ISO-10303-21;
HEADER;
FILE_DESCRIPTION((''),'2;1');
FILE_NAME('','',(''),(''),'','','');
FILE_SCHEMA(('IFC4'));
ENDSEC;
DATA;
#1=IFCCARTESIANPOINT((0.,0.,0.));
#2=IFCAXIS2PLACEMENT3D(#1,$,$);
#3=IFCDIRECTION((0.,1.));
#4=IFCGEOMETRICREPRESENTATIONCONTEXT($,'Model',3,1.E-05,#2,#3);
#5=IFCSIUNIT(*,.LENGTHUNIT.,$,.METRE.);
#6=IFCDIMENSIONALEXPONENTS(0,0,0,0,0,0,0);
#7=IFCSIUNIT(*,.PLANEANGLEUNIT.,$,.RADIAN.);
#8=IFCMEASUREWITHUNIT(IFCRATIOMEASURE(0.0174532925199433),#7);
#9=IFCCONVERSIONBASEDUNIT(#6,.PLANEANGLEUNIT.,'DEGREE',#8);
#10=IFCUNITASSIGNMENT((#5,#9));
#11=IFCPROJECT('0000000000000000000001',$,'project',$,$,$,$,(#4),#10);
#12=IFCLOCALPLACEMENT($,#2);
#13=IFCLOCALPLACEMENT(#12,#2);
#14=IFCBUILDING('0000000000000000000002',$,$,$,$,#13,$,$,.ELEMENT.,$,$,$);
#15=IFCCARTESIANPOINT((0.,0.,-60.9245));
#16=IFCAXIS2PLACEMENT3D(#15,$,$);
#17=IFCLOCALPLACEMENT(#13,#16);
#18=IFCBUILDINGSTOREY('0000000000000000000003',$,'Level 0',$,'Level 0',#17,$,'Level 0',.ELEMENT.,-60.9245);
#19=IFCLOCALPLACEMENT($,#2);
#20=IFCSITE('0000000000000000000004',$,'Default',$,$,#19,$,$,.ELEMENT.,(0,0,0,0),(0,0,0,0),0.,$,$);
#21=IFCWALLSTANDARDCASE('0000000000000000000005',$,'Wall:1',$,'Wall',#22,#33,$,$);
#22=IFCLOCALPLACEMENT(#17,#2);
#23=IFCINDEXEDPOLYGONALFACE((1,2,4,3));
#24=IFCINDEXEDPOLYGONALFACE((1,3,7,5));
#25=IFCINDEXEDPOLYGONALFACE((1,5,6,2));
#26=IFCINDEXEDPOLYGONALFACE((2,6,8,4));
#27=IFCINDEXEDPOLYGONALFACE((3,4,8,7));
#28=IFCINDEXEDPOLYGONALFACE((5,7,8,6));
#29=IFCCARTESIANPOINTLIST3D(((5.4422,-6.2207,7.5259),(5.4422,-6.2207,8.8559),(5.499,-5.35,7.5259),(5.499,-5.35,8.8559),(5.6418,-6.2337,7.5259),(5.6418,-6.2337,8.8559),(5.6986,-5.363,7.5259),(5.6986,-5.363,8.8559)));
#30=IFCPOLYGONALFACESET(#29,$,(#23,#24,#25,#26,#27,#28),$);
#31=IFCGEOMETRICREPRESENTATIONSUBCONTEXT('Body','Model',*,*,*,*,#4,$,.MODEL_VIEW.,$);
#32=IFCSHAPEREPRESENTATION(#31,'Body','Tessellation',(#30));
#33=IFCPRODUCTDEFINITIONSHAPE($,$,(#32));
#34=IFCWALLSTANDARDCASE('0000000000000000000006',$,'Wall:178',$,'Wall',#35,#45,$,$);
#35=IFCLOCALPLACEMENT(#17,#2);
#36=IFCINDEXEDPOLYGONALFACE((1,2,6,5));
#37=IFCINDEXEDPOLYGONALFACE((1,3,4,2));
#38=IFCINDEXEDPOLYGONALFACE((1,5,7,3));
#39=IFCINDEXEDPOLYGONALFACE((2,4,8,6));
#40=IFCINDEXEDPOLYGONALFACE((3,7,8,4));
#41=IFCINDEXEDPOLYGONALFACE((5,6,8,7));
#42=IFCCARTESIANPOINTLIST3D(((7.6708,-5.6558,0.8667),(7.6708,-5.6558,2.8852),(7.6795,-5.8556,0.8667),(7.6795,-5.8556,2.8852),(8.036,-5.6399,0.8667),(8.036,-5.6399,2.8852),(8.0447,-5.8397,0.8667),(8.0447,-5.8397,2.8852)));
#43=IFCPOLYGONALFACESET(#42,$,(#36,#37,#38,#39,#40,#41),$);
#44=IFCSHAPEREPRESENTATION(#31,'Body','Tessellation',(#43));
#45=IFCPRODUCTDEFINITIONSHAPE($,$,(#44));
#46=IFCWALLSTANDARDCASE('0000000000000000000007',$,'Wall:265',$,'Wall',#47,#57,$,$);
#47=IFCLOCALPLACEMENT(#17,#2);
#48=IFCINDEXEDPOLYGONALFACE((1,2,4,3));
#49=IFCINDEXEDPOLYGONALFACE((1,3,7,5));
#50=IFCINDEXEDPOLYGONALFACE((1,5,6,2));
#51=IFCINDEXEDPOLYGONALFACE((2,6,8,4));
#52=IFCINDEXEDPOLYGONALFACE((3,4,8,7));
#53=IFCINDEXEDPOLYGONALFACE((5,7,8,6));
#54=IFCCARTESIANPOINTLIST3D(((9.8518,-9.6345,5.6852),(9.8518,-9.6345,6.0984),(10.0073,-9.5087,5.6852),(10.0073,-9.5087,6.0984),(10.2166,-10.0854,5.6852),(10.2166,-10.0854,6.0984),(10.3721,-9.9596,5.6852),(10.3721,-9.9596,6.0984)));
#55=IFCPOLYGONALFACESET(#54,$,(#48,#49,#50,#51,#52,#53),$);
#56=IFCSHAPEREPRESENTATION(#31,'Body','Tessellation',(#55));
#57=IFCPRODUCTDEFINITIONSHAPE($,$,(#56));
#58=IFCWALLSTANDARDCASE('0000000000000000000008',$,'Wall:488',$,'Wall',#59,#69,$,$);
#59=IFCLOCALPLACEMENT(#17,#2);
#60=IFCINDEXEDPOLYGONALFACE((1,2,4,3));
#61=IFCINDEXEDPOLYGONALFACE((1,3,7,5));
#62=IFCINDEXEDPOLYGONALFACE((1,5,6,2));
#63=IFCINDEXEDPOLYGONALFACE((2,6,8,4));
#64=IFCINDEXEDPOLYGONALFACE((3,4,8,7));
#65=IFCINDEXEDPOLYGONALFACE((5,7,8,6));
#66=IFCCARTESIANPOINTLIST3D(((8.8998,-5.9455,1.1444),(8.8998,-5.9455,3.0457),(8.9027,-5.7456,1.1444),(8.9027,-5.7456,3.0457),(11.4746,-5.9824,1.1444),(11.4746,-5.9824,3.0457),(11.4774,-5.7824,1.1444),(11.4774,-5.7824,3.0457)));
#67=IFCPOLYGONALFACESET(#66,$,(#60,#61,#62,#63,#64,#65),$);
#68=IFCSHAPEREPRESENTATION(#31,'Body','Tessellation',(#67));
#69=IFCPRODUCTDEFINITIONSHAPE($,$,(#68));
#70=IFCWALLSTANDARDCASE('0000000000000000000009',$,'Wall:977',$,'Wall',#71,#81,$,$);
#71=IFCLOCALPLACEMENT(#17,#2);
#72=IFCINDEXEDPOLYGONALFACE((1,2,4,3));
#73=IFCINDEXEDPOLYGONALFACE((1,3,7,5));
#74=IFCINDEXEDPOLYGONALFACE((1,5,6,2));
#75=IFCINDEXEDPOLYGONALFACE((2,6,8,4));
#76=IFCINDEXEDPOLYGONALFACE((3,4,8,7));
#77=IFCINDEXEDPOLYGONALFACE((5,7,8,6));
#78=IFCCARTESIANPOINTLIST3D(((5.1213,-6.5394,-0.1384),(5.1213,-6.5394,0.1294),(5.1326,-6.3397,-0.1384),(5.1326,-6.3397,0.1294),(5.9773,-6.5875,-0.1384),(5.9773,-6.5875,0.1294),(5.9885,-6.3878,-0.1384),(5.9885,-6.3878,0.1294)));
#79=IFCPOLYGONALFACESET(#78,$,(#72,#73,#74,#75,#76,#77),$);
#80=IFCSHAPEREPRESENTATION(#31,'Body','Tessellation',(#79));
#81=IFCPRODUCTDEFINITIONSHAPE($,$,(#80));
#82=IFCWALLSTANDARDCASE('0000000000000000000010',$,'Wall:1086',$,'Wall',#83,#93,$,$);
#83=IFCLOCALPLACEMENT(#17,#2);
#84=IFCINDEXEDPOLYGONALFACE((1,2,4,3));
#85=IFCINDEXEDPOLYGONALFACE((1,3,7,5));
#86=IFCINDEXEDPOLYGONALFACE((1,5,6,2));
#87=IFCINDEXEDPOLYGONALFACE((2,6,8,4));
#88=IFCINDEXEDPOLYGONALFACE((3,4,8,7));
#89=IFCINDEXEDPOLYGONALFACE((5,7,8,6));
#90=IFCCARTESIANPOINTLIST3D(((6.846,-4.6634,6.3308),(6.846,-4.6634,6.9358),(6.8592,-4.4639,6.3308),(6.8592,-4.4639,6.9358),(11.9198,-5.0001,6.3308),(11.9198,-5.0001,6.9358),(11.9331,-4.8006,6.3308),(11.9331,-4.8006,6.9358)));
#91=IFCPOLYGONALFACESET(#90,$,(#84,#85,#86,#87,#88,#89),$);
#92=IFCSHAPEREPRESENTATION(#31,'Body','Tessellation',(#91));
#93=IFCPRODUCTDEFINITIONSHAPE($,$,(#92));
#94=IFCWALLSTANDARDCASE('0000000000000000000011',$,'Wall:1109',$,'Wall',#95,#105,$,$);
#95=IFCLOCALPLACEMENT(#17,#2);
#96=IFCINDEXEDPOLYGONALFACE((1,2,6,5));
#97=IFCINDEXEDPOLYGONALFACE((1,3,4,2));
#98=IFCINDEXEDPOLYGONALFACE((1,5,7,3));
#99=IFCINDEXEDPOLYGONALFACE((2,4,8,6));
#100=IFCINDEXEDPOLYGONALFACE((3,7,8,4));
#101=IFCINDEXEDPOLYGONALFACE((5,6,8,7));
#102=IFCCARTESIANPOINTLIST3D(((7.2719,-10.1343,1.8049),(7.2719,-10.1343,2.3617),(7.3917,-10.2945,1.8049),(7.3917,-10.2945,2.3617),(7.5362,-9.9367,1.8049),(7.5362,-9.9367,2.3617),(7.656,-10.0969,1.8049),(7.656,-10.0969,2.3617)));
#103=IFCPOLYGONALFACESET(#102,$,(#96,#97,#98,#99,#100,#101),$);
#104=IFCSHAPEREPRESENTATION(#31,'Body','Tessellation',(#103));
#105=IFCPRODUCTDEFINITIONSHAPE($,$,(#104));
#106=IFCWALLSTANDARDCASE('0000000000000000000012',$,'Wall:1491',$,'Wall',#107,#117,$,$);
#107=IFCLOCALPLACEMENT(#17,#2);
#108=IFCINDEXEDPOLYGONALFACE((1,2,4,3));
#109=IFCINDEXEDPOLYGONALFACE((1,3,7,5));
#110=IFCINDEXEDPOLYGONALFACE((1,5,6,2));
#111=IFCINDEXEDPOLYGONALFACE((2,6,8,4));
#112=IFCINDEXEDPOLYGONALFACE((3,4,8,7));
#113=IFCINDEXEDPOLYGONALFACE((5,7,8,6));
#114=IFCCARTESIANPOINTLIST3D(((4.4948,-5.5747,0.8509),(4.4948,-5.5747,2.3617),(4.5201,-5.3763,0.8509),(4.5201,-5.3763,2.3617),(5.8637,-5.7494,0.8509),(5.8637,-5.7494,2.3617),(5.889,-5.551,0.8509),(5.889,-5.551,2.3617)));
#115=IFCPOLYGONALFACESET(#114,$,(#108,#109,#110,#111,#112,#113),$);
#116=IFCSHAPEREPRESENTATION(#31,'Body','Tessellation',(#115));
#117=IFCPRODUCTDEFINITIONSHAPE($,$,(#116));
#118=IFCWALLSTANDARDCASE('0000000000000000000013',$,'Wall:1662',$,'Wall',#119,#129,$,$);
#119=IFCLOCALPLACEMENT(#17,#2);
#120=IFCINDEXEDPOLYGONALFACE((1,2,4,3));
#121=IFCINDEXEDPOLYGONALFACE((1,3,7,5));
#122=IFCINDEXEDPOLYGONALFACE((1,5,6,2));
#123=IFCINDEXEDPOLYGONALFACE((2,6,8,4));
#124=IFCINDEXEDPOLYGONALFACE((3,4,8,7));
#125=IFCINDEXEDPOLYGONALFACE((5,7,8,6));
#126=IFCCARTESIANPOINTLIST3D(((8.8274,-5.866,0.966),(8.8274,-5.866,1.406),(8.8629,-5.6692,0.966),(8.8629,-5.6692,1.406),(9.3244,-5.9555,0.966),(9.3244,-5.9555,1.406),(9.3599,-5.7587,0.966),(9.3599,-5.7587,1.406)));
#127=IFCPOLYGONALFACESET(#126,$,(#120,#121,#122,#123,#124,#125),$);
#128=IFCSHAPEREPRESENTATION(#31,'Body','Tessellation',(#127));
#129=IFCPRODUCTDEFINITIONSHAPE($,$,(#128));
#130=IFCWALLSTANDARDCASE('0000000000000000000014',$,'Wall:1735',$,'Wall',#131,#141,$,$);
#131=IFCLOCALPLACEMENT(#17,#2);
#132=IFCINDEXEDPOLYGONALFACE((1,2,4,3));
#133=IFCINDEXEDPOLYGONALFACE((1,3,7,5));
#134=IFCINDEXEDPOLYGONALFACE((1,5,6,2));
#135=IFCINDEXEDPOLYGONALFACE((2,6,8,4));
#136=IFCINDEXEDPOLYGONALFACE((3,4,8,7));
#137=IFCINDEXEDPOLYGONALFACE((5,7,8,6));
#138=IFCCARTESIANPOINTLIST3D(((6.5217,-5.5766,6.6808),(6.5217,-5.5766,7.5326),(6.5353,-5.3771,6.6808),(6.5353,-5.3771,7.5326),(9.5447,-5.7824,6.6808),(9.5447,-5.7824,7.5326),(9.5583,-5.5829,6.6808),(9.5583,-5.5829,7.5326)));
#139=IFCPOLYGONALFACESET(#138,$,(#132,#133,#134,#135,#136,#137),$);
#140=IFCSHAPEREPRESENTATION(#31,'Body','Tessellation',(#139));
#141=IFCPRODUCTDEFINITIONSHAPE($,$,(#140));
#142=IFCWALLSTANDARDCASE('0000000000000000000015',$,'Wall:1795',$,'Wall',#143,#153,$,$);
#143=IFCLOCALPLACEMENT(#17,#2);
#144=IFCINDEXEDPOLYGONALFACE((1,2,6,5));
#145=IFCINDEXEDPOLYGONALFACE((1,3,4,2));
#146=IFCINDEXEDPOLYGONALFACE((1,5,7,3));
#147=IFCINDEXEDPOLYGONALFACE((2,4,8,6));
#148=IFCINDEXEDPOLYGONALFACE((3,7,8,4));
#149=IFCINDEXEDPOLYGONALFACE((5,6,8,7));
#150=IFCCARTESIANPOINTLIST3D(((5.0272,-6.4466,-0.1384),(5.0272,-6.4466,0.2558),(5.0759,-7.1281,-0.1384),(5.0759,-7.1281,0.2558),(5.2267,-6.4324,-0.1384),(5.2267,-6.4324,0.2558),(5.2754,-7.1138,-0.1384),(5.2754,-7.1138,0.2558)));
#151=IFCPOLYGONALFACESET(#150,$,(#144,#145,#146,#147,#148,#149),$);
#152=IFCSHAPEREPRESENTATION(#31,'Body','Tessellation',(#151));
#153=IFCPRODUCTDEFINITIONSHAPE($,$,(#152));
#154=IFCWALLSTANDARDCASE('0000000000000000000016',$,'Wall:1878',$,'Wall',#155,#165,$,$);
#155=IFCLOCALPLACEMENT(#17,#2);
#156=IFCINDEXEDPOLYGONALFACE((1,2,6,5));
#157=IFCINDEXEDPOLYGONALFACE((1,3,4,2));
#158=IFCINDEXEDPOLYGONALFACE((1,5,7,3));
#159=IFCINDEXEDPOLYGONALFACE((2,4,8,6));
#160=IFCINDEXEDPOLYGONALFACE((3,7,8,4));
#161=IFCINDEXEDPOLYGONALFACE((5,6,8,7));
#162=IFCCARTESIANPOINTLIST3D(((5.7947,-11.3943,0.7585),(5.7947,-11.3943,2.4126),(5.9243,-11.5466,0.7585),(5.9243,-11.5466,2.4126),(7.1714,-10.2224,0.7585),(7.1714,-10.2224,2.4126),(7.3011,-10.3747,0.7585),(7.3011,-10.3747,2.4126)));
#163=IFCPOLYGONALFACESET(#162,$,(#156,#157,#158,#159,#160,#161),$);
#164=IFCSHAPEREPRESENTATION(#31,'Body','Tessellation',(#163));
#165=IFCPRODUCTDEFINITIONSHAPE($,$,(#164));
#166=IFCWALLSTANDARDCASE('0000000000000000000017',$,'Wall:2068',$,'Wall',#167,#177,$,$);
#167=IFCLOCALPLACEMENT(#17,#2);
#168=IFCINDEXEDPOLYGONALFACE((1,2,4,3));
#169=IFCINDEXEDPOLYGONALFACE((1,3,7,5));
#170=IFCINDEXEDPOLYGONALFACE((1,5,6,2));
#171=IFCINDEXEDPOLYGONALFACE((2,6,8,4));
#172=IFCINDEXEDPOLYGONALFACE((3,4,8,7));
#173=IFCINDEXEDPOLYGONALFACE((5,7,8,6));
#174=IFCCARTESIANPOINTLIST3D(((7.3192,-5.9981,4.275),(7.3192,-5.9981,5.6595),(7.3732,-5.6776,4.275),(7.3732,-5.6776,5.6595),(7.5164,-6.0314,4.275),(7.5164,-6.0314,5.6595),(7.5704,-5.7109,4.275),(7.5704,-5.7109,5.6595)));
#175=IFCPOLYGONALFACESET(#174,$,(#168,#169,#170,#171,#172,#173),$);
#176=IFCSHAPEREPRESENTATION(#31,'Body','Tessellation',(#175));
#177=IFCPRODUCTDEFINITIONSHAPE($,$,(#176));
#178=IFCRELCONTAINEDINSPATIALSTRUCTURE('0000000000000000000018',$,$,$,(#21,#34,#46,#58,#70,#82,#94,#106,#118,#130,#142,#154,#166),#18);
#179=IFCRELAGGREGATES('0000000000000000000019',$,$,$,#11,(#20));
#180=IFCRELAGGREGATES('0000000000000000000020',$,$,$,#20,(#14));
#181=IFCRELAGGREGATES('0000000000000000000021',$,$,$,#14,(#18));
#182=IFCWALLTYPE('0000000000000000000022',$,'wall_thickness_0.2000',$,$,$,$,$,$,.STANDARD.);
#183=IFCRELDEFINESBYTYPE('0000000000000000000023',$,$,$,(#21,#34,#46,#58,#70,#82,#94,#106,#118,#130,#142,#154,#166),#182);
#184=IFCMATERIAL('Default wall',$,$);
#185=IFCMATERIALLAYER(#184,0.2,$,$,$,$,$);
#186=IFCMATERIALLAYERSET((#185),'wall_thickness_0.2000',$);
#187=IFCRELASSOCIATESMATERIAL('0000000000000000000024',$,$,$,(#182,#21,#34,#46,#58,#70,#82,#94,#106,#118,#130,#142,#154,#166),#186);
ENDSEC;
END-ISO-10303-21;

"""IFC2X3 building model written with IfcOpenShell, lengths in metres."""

from ifc_helpers import new_model, entity, si_unit, converted_unit, direction, frame, origin, place, context, subcontext, project, spatial, polyline, outline, extrude, material, layer, layer_set, layer_usage, type_object, element, save


model = new_model("IFC2X3")

# Units and contexts
model_context = context("Model", 3, precision=1e-05, world=origin(), true_north=direction((0.0, 1.0)))
body_context = subcontext(model_context, "Body", "Model", "MODEL_VIEW")
ifc_project = project(units=[si_unit("LENGTHUNIT", "METRE"), converted_unit("PLANEANGLEUNIT", "DEGREE", entity("IfcRatioMeasure", 0.0174532925199433), si_unit("PLANEANGLEUNIT", "RADIAN"), dimensions=[0, 0, 0, 0, 0, 0, 0])], contexts=[model_context])

# Site, building, storey
site_placement = place(None, origin())
site = spatial("IfcSite", under=ifc_project, at=site_placement, Name="Default", CompositionType="ELEMENT", RefLatitude=(0, 0, 0, 0), RefLongitude=(0, 0, 0, 0), RefElevation=0.0)
placement_1 = place(None, origin())
building_placement = place(placement_1, origin())
building = spatial("IfcBuilding", under=site, at=building_placement, CompositionType="ELEMENT")
storey_placement = place(building_placement, frame((0.0, 0.0, -60.9245)))
storey = spatial("IfcBuildingStorey", under=building, at=storey_placement, Name="Level 0", ObjectType="Level 0", LongName="Level 0", CompositionType="ELEMENT", Elevation=-60.9245)

# Walls
ifc_material = material(Name="Default wall")
ifc_layer = layer(ifc_material, 0.2)
ifc_layer_set = layer_set([ifc_layer], Name="wall_thickness_0.2000")
ifc_layer_usage = layer_usage(ifc_layer_set, "AXIS2", "POSITIVE", -0.1)
wall_type = type_object("IfcWallType", Name="wall_thickness_0.2000", PredefinedType="STANDARD", material=ifc_layer_set)
placement_2 = place(building_placement, frame((0.0, 0.0, -53.3986)))
wall_1_placement = place(placement_2, frame((5.5988, -5.3565, 0.0), z_axis=(0.0, 0.0, 1.0), x_axis=(-0.065035, -0.997883, 0.0)))
element("IfcWallStandardCase", 1, at=wall_1_placement, inside=storey, type_object=wall_type, material=ifc_layer_usage, Name="Wall:1", ObjectType="Wall", context=body_context, shape_type="SweptSolid", body=[
    extrude(outline(polyline([(0.8725, -0.1), (0.8725, 0.1), (0.0, 0.1), (0.0, -0.1), (0.8725, -0.1)])), origin(), (0.0, 0.0, 1.0), 1.33),
])
placement_3 = place(building_placement, frame((0.0, 0.0, -60.0578)))
wall_2_placement = place(placement_3, frame((8.0403, -5.7398, 0.0), z_axis=(0.0, 0.0, 1.0), x_axis=(-0.999056, -0.043434, 0.0)))
element("IfcWallStandardCase", 2, at=wall_2_placement, inside=storey, type_object=wall_type, material=ifc_layer_usage, Name="Wall:178", ObjectType="Wall", context=body_context, shape_type="SweptSolid", body=[
    extrude(outline(polyline([(0.3655, -0.1), (0.3655, 0.1), (0.0, 0.1), (0.0, -0.1), (0.3655, -0.1)])), origin(), (0.0, 0.0, 1.0), 2.0185),
])
placement_4 = place(building_placement, frame((0.0, 0.0, -55.2393)))
wall_3_placement = place(placement_4, frame((9.9296, -9.5716, 0.0), z_axis=(0.0, 0.0, 1.0), x_axis=(0.628927, -0.777465, 0.0)))
element("IfcWallStandardCase", 3, at=wall_3_placement, inside=storey, type_object=wall_type, material=ifc_layer_usage, Name="Wall:265", ObjectType="Wall", context=body_context, shape_type="SweptSolid", body=[
    extrude(outline(polyline([(0.58, -0.1), (0.58, 0.1), (0.0, 0.1), (0.0, -0.1), (0.58, -0.1)])), origin(), (0.0, 0.0, 1.0), 0.4132),
])
placement_5 = place(building_placement, frame((0.0, 0.0, -59.7801)))
wall_4_placement = place(placement_5, frame((8.9013, -5.8456, 0.0), z_axis=(0.0, 0.0, 1.0), x_axis=(0.999897, -0.01432, 0.0)))
element("IfcWallStandardCase", 4, at=wall_4_placement, inside=storey, type_object=wall_type, material=ifc_layer_usage, Name="Wall:488", ObjectType="Wall", context=body_context, shape_type="SweptSolid", body=[
    extrude(outline(polyline([(2.575, -0.1), (2.575, 0.1), (0.0, 0.1), (0.0, -0.1), (2.575, -0.1)])), origin(), (0.0, 0.0, 1.0), 1.9012),
])
placement_6 = place(building_placement, frame((0.0, 0.0, -61.0629)))
wall_5_placement = place(placement_6, frame((5.1269, -6.4395, 0.0), z_axis=(0.0, 0.0, 1.0), x_axis=(0.99842, -0.056188, 0.0)))
element("IfcWallStandardCase", 5, at=wall_5_placement, inside=storey, type_object=wall_type, material=ifc_layer_usage, Name="Wall:977", ObjectType="Wall", context=body_context, shape_type="SweptSolid", body=[
    extrude(outline(polyline([(0.8573, -0.1), (0.8573, 0.1), (0.0, 0.1), (0.0, -0.1), (0.8573, -0.1)])), origin(), (0.0, 0.0, 1.0), 0.2677),
])
placement_7 = place(building_placement, frame((0.0, 0.0, -54.5937)))
wall_6_placement = place(placement_7, frame((6.8526, -4.5636, 0.0), z_axis=(0.0, 0.0, 1.0), x_axis=(0.997805, -0.066213, 0.0)))
element("IfcWallStandardCase", 6, at=wall_6_placement, inside=storey, type_object=wall_type, material=ifc_layer_usage, Name="Wall:1086", ObjectType="Wall", context=body_context, shape_type="SweptSolid", body=[
    extrude(outline(polyline([(5.085, -0.1), (5.085, 0.1), (0.0, 0.1), (0.0, -0.1), (5.085, -0.1)])), origin(), (0.0, 0.0, 1.0), 0.6049),
])
placement_8 = place(building_placement, frame((0.0, 0.0, -59.1196)))
wall_7_placement = place(placement_8, frame((7.3318, -10.2144, 0.0), z_axis=(0.0, 0.0, 1.0), x_axis=(0.800905, 0.598792, 0.0)))
element("IfcWallStandardCase", 7, at=wall_7_placement, inside=storey, type_object=wall_type, material=ifc_layer_usage, Name="Wall:1109", ObjectType="Wall", context=body_context, shape_type="SweptSolid", body=[
    extrude(outline(polyline([(0.33, -0.1), (0.33, 0.1), (0.0, 0.1), (0.0, -0.1), (0.33, -0.1)])), origin(), (0.0, 0.0, 1.0), 0.5568),
])
placement_9 = place(building_placement, frame((0.0, 0.0, -60.0736)))
wall_8_placement = place(placement_9, frame((5.8764, -5.6502, 0.0), z_axis=(0.0, 0.0, 1.0), x_axis=(-0.991959, 0.126556, 0.0)))
element("IfcWallStandardCase", 8, at=wall_8_placement, inside=storey, type_object=wall_type, material=ifc_layer_usage, Name="Wall:1491", ObjectType="Wall", context=body_context, shape_type="SweptSolid", body=[
    extrude(outline(polyline([(1.38, -0.1), (1.38, 0.1), (0.0, 0.1), (0.0, -0.1), (1.38, -0.1)])), origin(), (0.0, 0.0, 1.0), 1.5109),
])
placement_10 = place(building_placement, frame((0.0, 0.0, -59.9585)))
wall_9_placement = place(placement_10, frame((8.8451, -5.7676, 0.0), z_axis=(0.0, 0.0, 1.0), x_axis=(0.984172, -0.177215, 0.0)))
element("IfcWallStandardCase", 9, at=wall_9_placement, inside=storey, type_object=wall_type, material=ifc_layer_usage, Name="Wall:1662", ObjectType="Wall", context=body_context, shape_type="SweptSolid", body=[
    extrude(outline(polyline([(0.505, -0.1), (0.505, 0.1), (0.0, 0.1), (0.0, -0.1), (0.505, -0.1)])), origin(), (0.0, 0.0, 1.0), 0.4401),
])
placement_11 = place(building_placement, frame((0.0, 0.0, -54.2437)))
wall_10_placement = place(placement_11, frame((6.5285, -5.4768, 0.0), z_axis=(0.0, 0.0, 1.0), x_axis=(0.997691, -0.067923, 0.0)))
element("IfcWallStandardCase", 10, at=wall_10_placement, inside=storey, type_object=wall_type, material=ifc_layer_usage, Name="Wall:1735", ObjectType="Wall", context=body_context, shape_type="SweptSolid", body=[
    extrude(outline(polyline([(3.03, -0.1), (3.03, 0.1), (0.0, 0.1), (0.0, -0.1), (3.03, -0.1)])), origin(), (0.0, 0.0, 1.0), 0.8518),
])
placement_12 = place(building_placement, frame((0.0, 0.0, -61.0629)))
wall_11_placement = place(placement_12, frame((5.1269, -6.4395, 0.0), z_axis=(0.0, 0.0, 1.0), x_axis=(0.071292, -0.997455, 0.0)))
element("IfcWallStandardCase", 11, at=wall_11_placement, inside=storey, type_object=wall_type, material=ifc_layer_usage, Name="Wall:1795", ObjectType="Wall", context=body_context, shape_type="SweptSolid", body=[
    extrude(outline(polyline([(0.6832, -0.1), (0.6832, 0.1), (0.0, 0.1), (0.0, -0.1), (0.6832, -0.1)])), origin(), (0.0, 0.0, 1.0), 0.3942),
])
placement_13 = place(building_placement, frame((0.0, 0.0, -60.166)))
wall_12_placement = place(placement_13, frame((7.2363, -10.2985, 0.0), z_axis=(0.0, 0.0, 1.0), x_axis=(-0.761492, -0.648174, 0.0)))
element("IfcWallStandardCase", 12, at=wall_12_placement, inside=storey, type_object=wall_type, material=ifc_layer_usage, Name="Wall:1878", ObjectType="Wall", context=body_context, shape_type="SweptSolid", body=[
    extrude(outline(polyline([(1.8079, -0.1), (1.8079, 0.1), (0.0, 0.1), (0.0, -0.1), (1.8079, -0.1)])), origin(), (0.0, 0.0, 1.0), 1.6541),
])
placement_14 = place(building_placement, frame((0.0, 0.0, -56.6495)))
wall_13_placement = place(placement_14, frame((7.4718, -5.6943, 0.0), z_axis=(0.0, 0.0, 1.0), x_axis=(-0.166424, -0.986054, 0.0)))
element("IfcWallStandardCase", 13, at=wall_13_placement, inside=storey, type_object=wall_type, material=ifc_layer_usage, Name="Wall:2068", ObjectType="Wall", context=body_context, shape_type="SweptSolid", body=[
    extrude(outline(polyline([(0.325, -0.1), (0.325, 0.1), (0.0, 0.1), (0.0, -0.1), (0.325, -0.1)])), origin(), (0.0, 0.0, 1.0), 1.3845),
])

save(model, "model.ifc")
